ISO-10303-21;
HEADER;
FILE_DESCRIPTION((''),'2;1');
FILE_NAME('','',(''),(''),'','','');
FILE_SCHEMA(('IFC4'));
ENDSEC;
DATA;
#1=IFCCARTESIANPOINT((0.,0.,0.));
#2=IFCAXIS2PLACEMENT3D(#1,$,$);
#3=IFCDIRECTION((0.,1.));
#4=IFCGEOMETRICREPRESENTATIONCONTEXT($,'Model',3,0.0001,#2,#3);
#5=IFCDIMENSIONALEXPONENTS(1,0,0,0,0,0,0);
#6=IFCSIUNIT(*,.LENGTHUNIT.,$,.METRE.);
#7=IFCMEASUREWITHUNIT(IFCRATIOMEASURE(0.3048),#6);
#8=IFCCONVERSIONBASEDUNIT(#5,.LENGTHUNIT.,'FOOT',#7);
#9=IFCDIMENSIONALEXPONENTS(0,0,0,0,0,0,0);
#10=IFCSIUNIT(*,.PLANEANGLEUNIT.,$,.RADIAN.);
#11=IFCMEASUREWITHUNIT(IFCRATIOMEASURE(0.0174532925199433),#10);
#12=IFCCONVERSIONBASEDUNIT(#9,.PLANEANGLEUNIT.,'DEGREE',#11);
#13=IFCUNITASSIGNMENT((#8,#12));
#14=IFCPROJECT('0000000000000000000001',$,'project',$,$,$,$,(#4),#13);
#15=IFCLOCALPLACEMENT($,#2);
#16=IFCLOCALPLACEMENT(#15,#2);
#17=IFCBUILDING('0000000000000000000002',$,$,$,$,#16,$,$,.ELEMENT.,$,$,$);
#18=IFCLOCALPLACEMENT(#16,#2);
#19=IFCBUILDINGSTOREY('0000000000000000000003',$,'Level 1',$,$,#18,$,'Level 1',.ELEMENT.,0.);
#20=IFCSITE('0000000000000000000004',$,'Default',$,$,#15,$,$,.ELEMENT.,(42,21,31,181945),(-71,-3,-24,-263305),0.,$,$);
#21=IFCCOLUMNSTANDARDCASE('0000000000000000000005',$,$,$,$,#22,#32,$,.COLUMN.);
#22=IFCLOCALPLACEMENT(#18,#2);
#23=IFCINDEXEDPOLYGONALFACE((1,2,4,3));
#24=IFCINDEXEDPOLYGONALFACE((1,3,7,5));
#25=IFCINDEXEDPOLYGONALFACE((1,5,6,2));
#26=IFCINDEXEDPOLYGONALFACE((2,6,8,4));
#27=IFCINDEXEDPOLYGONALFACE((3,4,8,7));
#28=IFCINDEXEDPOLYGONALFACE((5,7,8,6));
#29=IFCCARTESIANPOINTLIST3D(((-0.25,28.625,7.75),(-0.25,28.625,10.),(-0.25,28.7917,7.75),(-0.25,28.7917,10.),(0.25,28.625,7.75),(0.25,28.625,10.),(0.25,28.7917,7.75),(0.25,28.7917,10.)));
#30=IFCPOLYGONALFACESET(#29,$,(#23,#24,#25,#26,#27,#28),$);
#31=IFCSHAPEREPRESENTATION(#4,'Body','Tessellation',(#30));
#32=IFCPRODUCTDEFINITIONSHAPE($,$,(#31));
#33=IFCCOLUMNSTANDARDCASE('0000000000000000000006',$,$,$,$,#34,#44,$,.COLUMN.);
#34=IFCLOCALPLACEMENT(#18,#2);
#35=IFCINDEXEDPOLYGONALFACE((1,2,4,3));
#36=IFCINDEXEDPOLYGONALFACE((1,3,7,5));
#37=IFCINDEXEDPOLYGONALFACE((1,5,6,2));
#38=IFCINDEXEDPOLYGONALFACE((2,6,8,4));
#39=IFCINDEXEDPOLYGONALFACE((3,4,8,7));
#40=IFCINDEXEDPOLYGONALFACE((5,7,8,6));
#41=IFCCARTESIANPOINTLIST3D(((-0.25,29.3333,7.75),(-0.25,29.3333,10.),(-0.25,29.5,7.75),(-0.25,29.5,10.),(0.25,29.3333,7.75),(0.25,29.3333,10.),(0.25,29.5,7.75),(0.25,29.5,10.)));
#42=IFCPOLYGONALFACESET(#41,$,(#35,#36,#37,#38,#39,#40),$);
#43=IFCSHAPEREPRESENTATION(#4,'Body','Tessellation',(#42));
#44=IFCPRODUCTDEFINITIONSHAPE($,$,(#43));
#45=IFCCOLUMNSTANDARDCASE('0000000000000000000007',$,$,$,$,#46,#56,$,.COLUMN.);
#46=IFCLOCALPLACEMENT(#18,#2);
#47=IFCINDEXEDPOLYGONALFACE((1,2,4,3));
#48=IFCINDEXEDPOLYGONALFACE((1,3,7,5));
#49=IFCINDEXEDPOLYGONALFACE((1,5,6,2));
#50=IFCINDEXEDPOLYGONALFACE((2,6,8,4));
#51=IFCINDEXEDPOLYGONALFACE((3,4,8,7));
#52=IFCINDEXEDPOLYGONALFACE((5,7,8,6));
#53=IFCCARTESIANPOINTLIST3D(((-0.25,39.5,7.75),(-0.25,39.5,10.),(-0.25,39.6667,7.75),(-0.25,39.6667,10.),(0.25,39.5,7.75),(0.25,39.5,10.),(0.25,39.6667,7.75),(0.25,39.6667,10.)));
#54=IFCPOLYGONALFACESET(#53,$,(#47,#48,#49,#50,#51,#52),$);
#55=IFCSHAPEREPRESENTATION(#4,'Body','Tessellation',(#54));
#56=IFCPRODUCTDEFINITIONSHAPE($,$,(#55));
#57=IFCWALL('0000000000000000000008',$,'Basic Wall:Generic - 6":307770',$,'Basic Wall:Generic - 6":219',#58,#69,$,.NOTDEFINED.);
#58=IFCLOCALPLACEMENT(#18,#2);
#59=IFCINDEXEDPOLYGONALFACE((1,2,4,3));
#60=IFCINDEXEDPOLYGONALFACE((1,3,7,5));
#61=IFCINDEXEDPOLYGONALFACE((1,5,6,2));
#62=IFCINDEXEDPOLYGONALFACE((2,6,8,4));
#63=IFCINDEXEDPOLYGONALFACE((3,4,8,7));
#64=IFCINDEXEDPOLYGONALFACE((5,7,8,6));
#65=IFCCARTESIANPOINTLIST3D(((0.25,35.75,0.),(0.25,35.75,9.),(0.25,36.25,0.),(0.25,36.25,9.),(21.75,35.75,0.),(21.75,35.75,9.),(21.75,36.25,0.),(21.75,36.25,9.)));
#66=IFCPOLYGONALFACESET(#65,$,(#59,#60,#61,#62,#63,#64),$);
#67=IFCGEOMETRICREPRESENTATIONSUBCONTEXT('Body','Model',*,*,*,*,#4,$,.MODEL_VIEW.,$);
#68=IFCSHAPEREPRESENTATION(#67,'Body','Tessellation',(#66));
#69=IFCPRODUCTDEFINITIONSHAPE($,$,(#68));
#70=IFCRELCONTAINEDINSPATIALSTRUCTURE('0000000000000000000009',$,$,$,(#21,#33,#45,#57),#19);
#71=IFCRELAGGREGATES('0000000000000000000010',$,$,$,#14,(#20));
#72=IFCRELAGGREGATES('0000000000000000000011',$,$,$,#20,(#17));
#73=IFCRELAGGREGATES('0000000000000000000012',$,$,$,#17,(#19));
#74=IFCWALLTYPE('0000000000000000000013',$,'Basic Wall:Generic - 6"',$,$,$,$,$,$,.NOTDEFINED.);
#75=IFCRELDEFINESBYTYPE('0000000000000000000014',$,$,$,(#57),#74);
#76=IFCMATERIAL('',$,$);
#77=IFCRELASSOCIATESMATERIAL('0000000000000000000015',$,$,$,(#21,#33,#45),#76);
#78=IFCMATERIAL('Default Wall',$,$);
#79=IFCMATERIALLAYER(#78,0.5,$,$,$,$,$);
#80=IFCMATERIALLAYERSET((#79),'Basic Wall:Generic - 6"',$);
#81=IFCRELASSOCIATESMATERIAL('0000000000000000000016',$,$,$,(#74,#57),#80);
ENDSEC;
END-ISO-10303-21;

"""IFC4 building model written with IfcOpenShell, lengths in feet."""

from ifc_helpers import new_model, entity, si_unit, converted_unit, direction, frame, frame_2d, origin, place, context, subcontext, project, spatial, rectangle, extrude, material, layer, layer_set, layer_usage, type_object, element, save


model = new_model("IFC4")

# Units and contexts
model_context = context("Model", 3, precision=0.0001, world=origin(), true_north=direction((0.0, 1.0)))
body_context = subcontext(model_context, "Body", "Model", "MODEL_VIEW")
ifc_project = project(units=[converted_unit("LENGTHUNIT", "FOOT", entity("IfcRatioMeasure", 0.3048), si_unit("LENGTHUNIT", "METRE"), dimensions=[1, 0, 0, 0, 0, 0, 0]), converted_unit("PLANEANGLEUNIT", "DEGREE", entity("IfcRatioMeasure", 0.0174532925199433), si_unit("PLANEANGLEUNIT", "RADIAN"), dimensions=[0, 0, 0, 0, 0, 0, 0])], contexts=[model_context])

# Site, building, storey
site_placement = place(None, origin())
site = spatial("IfcSite", under=ifc_project, at=site_placement, Name="Default", CompositionType="ELEMENT", RefLatitude=(42, 21, 31, 181945), RefLongitude=(-71, -3, -24, -263305), RefElevation=0.0)
building_placement = place(site_placement, origin())
building = spatial("IfcBuilding", under=site, at=building_placement, CompositionType="ELEMENT")
storey_placement = place(building_placement, origin())
storey = spatial("IfcBuildingStorey", under=building, at=storey_placement, Name="Level 1", LongName="Level 1", CompositionType="ELEMENT", Elevation=0.0)

# Columns
placement = place(storey_placement, frame((0.0, -0.25, 0.0), z_axis=(0.0, 0.0, 1.0), x_axis=(0.0, 1.0, 0.0)))
ifc_material_1 = material(Name="")
for number, where, z_axis, x_axis in (
    (1, (28.9583, 0.0, 7.75), (0.0, 0.0, 1.0), (1.0, 0.0, 0.0)),
    (2, (29.6667, 0.0, 7.75), (0.0, 0.0, 1.0), (1.0, 0.0, 0.0)),
    (3, (39.8334, 0.0, 7.75), (0.0, 0.0, 1.0), (1.0, 0.0, 0.0)),
):
    element("IfcColumnStandardCase", number, at=place(placement, frame(where, z_axis=z_axis, x_axis=x_axis)), inside=storey, material=ifc_material_1, PredefinedType="COLUMN", context=model_context, shape_type="SweptSolid", body=[
        extrude(rectangle(XDim=0.1667, YDim=0.5), origin(), (0.0, 0.0, 1.0), 2.25),
    ])

# Wall
ifc_material_2 = material(Name="Default Wall")
ifc_layer = layer(ifc_material_2, 0.5)
ifc_layer_set = layer_set([ifc_layer], Name="Basic Wall:Generic - 6\"")
ifc_layer_usage = layer_usage(ifc_layer_set, "AXIS2", "NEGATIVE", 0.25)
wall_type = type_object("IfcWallType", Name="Basic Wall:Generic - 6\"", PredefinedType="NOTDEFINED", material=ifc_layer_set)
wall_placement = place(storey_placement, frame((0.25, 36.0, 0.0)))
element("IfcWall", 4, at=wall_placement, inside=storey, type_object=wall_type, material=ifc_layer_usage, Name="Basic Wall:Generic - 6\":307770", ObjectType="Basic Wall:Generic - 6\":219", PredefinedType="NOTDEFINED", context=body_context, shape_type="SweptSolid", body=[
    extrude(rectangle(XDim=21.5, YDim=0.5, at=frame_2d((10.75, 0.0), x_axis=(-1.0, 0.0))), origin(), (0.0, 0.0, 1.0), 9.0),
])

save(model, "model.ifc")
